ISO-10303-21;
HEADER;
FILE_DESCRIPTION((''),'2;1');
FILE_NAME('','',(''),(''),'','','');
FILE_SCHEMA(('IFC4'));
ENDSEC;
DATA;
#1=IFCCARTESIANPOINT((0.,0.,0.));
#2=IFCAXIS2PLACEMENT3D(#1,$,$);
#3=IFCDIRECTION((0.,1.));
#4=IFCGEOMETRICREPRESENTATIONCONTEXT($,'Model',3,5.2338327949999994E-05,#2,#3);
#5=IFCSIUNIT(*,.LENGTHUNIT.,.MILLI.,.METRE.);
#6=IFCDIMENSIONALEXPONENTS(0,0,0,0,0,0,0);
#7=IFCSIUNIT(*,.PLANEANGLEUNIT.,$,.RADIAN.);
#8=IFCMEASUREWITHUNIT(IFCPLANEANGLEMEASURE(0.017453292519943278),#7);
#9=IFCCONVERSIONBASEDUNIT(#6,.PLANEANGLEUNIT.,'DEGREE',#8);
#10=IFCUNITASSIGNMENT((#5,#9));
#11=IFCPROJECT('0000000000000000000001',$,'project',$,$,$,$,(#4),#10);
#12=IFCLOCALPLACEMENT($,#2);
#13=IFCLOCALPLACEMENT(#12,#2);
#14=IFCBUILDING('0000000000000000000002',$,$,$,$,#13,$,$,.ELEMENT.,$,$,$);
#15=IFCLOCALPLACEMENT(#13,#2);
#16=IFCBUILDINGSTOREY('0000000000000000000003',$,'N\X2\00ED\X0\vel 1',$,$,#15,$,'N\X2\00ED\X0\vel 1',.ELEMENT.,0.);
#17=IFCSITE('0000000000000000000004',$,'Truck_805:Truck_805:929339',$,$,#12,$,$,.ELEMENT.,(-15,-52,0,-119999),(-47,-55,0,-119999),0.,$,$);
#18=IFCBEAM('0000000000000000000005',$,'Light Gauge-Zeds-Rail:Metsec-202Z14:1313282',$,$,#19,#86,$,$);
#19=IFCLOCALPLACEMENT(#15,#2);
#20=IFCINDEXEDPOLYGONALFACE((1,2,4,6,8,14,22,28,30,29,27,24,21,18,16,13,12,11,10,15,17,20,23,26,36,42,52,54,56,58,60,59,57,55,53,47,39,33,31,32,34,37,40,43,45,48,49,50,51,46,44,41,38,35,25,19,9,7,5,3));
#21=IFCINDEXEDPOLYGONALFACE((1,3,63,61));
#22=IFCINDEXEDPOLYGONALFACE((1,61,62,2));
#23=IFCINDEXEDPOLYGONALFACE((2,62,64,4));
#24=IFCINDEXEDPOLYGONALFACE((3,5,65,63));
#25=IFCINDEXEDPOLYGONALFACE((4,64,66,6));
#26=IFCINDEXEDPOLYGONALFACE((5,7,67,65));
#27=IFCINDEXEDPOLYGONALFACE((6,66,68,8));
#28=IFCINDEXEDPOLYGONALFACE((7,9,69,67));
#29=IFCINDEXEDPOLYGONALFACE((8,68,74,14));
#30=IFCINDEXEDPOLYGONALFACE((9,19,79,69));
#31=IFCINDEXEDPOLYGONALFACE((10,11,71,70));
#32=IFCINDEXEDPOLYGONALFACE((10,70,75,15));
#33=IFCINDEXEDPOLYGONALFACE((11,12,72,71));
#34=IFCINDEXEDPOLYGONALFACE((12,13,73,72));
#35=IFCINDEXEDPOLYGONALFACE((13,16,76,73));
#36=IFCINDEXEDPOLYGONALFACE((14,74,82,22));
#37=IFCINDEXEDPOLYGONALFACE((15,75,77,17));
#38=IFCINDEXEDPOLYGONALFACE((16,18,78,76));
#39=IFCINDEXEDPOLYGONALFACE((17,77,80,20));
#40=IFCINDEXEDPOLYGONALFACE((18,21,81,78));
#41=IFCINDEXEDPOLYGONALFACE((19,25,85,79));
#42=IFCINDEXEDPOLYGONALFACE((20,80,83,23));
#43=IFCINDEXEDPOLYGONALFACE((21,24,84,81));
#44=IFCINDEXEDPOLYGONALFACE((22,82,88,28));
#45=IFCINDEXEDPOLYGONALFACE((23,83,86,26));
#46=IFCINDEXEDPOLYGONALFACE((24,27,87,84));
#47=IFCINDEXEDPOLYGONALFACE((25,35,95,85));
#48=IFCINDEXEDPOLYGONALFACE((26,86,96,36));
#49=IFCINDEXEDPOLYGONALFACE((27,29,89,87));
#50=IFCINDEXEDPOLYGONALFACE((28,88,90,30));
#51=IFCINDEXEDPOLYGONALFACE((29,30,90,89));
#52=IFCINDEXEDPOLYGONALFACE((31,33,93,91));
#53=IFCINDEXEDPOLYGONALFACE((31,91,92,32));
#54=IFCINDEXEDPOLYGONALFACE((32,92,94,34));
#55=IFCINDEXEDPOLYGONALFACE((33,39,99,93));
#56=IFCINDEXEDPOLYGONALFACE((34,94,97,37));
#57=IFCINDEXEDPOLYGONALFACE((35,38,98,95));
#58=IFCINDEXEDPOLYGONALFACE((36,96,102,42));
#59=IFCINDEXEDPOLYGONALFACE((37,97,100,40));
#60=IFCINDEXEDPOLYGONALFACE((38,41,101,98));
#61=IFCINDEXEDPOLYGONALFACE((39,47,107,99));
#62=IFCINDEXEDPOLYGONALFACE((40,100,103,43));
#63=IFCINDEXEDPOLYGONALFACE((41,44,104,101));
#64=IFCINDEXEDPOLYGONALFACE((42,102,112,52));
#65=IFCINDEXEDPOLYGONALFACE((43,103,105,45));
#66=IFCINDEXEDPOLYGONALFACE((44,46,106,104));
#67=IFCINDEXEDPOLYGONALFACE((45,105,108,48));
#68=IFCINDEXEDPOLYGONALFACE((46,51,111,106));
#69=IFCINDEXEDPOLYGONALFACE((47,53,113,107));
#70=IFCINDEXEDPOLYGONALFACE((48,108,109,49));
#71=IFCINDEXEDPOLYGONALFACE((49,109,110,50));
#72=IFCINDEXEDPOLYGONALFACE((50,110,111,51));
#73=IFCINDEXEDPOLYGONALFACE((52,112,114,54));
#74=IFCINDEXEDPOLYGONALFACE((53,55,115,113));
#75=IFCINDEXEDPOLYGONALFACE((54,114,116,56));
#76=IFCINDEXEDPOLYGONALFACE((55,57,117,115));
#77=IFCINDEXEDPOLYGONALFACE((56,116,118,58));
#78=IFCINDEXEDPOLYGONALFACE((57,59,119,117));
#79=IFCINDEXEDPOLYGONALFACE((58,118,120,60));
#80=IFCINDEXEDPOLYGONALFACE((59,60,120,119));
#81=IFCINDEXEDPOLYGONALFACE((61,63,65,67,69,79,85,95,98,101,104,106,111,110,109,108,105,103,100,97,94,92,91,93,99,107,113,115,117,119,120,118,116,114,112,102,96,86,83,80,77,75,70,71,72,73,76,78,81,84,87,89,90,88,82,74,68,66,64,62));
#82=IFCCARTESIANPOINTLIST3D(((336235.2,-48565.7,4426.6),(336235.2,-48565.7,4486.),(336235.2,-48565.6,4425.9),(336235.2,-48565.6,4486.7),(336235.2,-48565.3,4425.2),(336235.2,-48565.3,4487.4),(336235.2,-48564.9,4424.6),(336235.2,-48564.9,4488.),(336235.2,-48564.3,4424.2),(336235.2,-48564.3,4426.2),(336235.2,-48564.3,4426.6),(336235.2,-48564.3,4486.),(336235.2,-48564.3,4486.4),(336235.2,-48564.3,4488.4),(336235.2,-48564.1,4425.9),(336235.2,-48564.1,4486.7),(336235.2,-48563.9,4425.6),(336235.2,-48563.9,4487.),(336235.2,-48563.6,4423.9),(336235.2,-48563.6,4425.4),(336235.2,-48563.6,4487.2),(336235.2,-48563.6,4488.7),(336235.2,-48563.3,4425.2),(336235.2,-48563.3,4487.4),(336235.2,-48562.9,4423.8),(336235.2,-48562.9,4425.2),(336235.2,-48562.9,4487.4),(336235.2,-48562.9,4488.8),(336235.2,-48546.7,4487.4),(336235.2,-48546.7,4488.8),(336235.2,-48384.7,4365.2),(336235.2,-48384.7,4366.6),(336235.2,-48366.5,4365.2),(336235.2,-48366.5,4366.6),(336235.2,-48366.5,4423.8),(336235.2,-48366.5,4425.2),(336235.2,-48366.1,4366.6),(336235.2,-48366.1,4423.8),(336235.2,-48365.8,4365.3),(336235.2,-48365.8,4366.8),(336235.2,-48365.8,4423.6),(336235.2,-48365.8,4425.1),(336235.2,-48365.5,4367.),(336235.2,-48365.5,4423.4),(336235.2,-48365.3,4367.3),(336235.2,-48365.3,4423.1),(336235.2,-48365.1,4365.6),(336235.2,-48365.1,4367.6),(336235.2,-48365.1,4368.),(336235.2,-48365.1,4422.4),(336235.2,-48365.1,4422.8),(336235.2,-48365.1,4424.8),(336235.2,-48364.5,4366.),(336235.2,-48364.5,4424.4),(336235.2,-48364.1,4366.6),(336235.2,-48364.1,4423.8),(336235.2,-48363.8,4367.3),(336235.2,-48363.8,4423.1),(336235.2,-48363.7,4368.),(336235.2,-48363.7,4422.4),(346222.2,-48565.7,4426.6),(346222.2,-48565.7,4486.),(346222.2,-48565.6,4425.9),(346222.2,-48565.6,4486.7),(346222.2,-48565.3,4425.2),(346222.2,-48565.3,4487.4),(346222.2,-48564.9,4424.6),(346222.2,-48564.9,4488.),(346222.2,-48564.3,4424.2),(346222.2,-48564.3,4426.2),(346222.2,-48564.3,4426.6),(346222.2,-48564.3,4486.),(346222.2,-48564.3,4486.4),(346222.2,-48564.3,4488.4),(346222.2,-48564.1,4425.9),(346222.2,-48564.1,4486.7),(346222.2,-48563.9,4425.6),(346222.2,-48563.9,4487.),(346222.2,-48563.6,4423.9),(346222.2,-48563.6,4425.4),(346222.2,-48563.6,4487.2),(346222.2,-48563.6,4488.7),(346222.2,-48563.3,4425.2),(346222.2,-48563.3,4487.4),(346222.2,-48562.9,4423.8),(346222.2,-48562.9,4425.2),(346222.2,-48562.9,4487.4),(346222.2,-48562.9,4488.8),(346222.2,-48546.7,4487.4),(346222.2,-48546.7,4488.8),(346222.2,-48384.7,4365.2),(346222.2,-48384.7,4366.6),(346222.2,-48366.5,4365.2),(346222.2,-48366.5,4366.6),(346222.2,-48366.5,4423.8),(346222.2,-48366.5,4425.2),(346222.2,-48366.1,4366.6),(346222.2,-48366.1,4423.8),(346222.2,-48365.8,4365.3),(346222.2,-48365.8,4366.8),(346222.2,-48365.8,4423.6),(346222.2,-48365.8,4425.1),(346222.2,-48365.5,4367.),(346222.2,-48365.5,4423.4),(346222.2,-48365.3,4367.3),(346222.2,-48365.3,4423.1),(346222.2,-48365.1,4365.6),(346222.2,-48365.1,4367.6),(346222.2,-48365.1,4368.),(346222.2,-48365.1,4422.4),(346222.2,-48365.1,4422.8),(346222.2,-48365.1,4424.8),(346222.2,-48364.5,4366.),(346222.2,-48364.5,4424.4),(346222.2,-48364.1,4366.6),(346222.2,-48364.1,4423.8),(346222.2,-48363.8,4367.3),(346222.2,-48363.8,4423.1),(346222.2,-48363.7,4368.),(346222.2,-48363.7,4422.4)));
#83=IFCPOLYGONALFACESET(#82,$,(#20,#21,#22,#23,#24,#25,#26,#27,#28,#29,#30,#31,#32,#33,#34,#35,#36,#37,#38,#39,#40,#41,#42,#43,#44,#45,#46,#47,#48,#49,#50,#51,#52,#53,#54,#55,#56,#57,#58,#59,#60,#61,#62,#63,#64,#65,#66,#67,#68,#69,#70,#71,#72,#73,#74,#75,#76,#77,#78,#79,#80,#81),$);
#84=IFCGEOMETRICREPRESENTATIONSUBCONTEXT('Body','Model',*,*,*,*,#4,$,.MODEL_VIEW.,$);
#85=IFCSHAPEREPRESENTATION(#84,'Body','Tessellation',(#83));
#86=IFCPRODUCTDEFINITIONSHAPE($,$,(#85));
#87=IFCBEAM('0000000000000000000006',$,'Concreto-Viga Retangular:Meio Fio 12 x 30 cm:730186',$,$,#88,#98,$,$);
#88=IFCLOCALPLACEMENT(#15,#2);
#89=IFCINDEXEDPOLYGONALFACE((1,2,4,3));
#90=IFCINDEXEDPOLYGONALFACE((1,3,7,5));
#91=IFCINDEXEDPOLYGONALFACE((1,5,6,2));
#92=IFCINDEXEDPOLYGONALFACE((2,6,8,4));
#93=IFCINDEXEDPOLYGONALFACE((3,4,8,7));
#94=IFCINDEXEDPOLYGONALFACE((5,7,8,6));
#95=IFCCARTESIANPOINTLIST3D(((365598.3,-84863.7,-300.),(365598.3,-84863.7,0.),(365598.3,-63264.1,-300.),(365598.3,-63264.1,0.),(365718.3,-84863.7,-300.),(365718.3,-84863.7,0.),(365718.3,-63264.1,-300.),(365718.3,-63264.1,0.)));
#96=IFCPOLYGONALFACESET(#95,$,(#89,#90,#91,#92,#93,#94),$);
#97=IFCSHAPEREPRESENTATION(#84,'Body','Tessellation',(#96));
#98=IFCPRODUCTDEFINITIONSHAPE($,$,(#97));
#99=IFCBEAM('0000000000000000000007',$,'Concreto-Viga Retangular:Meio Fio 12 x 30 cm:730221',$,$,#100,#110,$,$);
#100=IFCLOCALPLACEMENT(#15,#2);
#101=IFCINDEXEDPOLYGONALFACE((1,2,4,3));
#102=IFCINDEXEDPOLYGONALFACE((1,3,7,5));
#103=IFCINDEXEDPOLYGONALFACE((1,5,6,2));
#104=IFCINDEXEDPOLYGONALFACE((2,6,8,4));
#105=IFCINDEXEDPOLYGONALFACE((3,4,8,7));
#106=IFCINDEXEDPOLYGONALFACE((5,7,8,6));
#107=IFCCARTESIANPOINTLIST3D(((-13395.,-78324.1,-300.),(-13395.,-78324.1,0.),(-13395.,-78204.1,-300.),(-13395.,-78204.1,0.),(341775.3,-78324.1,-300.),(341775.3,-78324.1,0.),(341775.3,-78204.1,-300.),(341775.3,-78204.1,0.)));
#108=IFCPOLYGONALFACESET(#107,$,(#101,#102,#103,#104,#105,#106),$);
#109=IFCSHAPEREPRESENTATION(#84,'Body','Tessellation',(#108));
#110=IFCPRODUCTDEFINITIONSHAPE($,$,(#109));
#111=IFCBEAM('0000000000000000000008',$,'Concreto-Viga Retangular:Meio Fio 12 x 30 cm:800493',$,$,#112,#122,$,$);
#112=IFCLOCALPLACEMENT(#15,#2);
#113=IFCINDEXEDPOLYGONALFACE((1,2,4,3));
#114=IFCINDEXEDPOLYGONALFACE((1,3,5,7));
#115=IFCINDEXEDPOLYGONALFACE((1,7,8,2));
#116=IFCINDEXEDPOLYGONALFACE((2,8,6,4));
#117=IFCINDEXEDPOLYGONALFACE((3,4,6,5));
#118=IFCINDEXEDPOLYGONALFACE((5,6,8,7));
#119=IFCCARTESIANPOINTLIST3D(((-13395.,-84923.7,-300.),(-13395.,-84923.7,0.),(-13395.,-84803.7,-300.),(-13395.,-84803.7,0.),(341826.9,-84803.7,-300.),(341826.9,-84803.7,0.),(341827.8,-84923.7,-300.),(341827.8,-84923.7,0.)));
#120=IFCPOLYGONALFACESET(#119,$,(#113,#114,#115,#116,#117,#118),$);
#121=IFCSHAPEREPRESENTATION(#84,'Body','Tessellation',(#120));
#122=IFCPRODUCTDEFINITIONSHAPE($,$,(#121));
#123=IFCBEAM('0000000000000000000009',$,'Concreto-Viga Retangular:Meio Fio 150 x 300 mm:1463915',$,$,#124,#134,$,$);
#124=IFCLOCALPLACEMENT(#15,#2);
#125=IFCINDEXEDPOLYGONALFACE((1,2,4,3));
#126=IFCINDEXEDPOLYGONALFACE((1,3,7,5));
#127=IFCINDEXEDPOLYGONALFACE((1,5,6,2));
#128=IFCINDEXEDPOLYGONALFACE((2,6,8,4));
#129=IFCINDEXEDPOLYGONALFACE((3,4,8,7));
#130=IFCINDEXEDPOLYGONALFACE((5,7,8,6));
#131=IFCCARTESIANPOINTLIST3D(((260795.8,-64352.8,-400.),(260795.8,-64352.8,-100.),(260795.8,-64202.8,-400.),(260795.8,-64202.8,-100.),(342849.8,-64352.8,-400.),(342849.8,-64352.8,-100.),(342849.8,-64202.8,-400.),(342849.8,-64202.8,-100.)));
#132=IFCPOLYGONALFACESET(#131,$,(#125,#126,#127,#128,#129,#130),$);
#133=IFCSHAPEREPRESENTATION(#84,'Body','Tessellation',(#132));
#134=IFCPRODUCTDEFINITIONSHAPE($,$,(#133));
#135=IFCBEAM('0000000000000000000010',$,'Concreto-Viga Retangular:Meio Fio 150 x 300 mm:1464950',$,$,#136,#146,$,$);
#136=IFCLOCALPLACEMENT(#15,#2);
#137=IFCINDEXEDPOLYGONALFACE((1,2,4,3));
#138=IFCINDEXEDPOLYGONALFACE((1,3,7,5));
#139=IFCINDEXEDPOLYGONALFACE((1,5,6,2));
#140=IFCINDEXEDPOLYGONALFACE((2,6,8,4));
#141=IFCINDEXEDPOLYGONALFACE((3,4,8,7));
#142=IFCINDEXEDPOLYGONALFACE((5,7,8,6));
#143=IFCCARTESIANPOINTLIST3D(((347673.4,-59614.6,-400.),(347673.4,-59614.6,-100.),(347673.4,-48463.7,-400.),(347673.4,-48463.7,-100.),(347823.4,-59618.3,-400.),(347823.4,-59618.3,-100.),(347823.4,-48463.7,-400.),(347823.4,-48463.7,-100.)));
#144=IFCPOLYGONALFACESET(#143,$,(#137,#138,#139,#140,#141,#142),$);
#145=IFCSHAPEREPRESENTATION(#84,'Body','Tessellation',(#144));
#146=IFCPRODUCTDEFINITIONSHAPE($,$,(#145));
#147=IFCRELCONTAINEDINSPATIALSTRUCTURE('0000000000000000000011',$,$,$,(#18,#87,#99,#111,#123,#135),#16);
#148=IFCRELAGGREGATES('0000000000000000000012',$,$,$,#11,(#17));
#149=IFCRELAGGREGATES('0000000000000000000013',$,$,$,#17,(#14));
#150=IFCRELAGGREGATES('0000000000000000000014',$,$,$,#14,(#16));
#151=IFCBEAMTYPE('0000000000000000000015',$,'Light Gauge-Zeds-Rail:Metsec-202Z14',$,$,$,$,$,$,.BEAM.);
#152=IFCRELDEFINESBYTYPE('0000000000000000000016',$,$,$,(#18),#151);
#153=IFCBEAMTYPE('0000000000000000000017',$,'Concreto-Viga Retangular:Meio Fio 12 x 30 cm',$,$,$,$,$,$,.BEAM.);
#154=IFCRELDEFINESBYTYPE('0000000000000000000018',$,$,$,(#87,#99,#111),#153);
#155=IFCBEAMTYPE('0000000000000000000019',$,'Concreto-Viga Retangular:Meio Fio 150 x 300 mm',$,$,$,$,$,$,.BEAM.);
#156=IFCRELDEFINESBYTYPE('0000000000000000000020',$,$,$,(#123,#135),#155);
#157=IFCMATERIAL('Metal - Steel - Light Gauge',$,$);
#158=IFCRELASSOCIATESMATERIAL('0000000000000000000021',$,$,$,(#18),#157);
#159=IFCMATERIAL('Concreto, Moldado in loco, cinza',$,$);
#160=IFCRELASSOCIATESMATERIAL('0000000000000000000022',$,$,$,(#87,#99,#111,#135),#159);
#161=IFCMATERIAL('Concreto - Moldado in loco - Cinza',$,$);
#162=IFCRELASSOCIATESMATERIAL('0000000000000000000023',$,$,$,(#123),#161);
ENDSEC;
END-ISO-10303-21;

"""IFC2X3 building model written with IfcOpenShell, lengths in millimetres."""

from ifc_helpers import new_model, entity, si_unit, converted_unit, direction, frame, frame_2d, origin, origin_2d_with_axis, place, context, subcontext, project, spatial, polyline, circle_curve, parameter, trimmed, segment, composite_curve, rectangle, outline, extrude, clip, halfspace, material, type_object, element, save


model = new_model("IFC2X3")

# Units and contexts
model_context = context("Model", 3, precision=5.2338327949999994e-05, world=origin(), true_north=direction((0.0, 1.0)))
body_context = subcontext(model_context, "Body", "Model", "MODEL_VIEW")
ifc_project = project(units=[si_unit("LENGTHUNIT", "METRE", prefix="MILLI"), converted_unit("PLANEANGLEUNIT", "DEGREE", entity("IfcPlaneAngleMeasure", 0.017453292519943278), si_unit("PLANEANGLEUNIT", "RADIAN"), dimensions=[0, 0, 0, 0, 0, 0, 0])], contexts=[model_context])

# Site, building, storey
site_placement = place(None, origin())
site = spatial("IfcSite", under=ifc_project, at=site_placement, Name="Truck_805:Truck_805:929339", CompositionType="ELEMENT", RefLatitude=(-15, -52, 0, -119999), RefLongitude=(-47, -55, 0, -119999), RefElevation=0.0)
building_placement = place(site_placement, origin())
building = spatial("IfcBuilding", under=site, at=building_placement, CompositionType="ELEMENT")
storey_placement = place(building_placement, origin())
storey = spatial("IfcBuildingStorey", under=building, at=storey_placement, Name="Nível 1", LongName="Nível 1", CompositionType="ELEMENT", Elevation=0.0)

# Beams
ifc_material_1 = material(Name="Metal - Steel - Light Gauge")
beam_type_1 = type_object("IfcBeamType", Name="Light Gauge-Zeds-Rail:Metsec-202Z14", PredefinedType="BEAM")
beam_1_placement = place(storey_placement, frame((336222.2, -48465.6, 4488.8)))
element("IfcBeam", 1, at=beam_1_placement, inside=storey, type_object=beam_type_1, material=ifc_material_1, Name="Light Gauge-Zeds-Rail:Metsec-202Z14:1313282", context=body_context, shape_type="SweptSolid", body=[
    extrude(outline(composite_curve([segment(polyline([(-60.0, -100.8), (-0.6, -100.8)]), True, "CONTINUOUS"), segment(trimmed(circle_curve(frame_2d((-0.6, -98.0), x_axis=(0.0, -1.0)), 2.8), [parameter(0.0)], [parameter(90.0)], True, "PARAMETER"), True, "CONTINUOUS"), segment(polyline([(2.2, -98.0), (2.2, 98.4)]), True, "CONTINUOUS"), segment(trimmed(circle_curve(frame_2d((3.6, 98.4), x_axis=(-1.0, 0.0)), 1.4), [parameter(270.0)], [parameter(0.0)], True, "PARAMETER"), False, "CONTINUOUS"), segment(polyline([(3.6, 99.8), (58.0, 99.8)]), True, "CONTINUOUS"), segment(trimmed(circle_curve(frame_2d((58.0, 98.4), x_axis=(0.0, 1.0)), 1.4), [parameter(270.0)], [parameter(0.0)], True, "PARAMETER"), False, "CONTINUOUS"), segment(polyline([(59.4, 98.4), (59.4, 80.2)]), True, "CONTINUOUS"), segment(polyline([(59.4, 80.2), (60.8, 80.2)]), True, "CONTINUOUS"), segment(polyline([(60.8, 80.2), (60.8, 98.4)]), True, "CONTINUOUS"), segment(trimmed(circle_curve(frame_2d((58.0, 98.4), x_axis=(1.0, 0.0)), 2.8), [parameter(0.0)], [parameter(90.0)], True, "PARAMETER"), True, "CONTINUOUS"), segment(polyline([(58.0, 101.2), (3.6, 101.2)]), True, "CONTINUOUS"), segment(trimmed(circle_curve(frame_2d((3.6, 98.4), x_axis=(0.0, 1.0)), 2.8), [parameter(0.0)], [parameter(90.0)], True, "PARAMETER"), True, "CONTINUOUS"), segment(polyline([(0.8, 98.4), (0.8, -98.0)]), True, "CONTINUOUS"), segment(trimmed(circle_curve(frame_2d((-0.6, -98.0), x_axis=(1.0, 0.0)), 1.4), [parameter(270.0)], [parameter(0.0)], True, "PARAMETER"), False, "CONTINUOUS"), segment(polyline([(-0.6, -99.4), (-60.0, -99.4)]), True, "CONTINUOUS"), segment(trimmed(circle_curve(frame_2d((-60.0, -98.0), x_axis=(0.0, -1.0)), 1.4), [parameter(270.0)], [parameter(0.0)], True, "PARAMETER"), False, "CONTINUOUS"), segment(polyline([(-61.4, -98.0), (-61.4, -81.8)]), True, "CONTINUOUS"), segment(polyline([(-61.4, -81.8), (-62.8, -81.8)]), True, "CONTINUOUS"), segment(polyline([(-62.8, -81.8), (-62.8, -98.0)]), True, "CONTINUOUS"), segment(trimmed(circle_curve(frame_2d((-60.0, -98.0), x_axis=(-1.0, 0.0)), 2.8), [parameter(0.0)], [parameter(90.0)], True, "PARAMETER"), True, "CONTINUOUS")], self_intersect=False)), frame((13.0, 0.7, -62.8), z_axis=(1.0, 0.0, 0.0), x_axis=(0.0, 0.0, -1.0)), (0.0, 0.0, 1.0), 9987.0),
])
ifc_material_2 = material(Name="Concreto, Moldado in loco, cinza")
beam_type_2 = type_object("IfcBeamType", Name="Concreto-Viga Retangular:Meio Fio 12 x 30 cm", PredefinedType="BEAM")
beam_2_placement = place(storey_placement, frame((365658.3, -63264.1, 0.0), z_axis=(0.0, 0.0, 1.0), x_axis=(0.0, -1.0, 0.0)))
element("IfcBeam", 2, at=beam_2_placement, inside=storey, type_object=beam_type_2, material=ifc_material_2, Name="Concreto-Viga Retangular:Meio Fio 12 x 30 cm:730186", context=body_context, shape_type="SweptSolid", body=[
    extrude(rectangle(XDim=300.0, YDim=120.0, at=frame_2d((0.0, 0.0), x_axis=(1.0, 0.0))), frame((0.0, 0.0, -150.0), z_axis=(1.0, 0.0, 0.0), x_axis=(0.0, 0.0, -1.0)), (0.0, 0.0, 1.0), 21599.6),
])
beam_3_placement = place(storey_placement, frame((341775.3, -78264.1, 0.0), z_axis=(0.0, 0.0, 1.0), x_axis=(-1.0, 0.0, 0.0)))
element("IfcBeam", 3, at=beam_3_placement, inside=storey, type_object=beam_type_2, material=ifc_material_2, Name="Concreto-Viga Retangular:Meio Fio 12 x 30 cm:730221", context=body_context, shape_type="SweptSolid", body=[
    extrude(rectangle(XDim=300.0, YDim=120.0, at=frame_2d((0.0, 0.0), x_axis=(1.0, 0.0))), frame((0.0, 0.0, -150.0), z_axis=(1.0, 0.0, 0.0), x_axis=(0.0, 0.0, -1.0)), (0.0, 0.0, 1.0), 355170.3),
])
beam_4_placement = place(storey_placement, frame((341827.3, -84863.7, 0.0), z_axis=(0.0, 0.0, 1.0), x_axis=(-1.0, 0.0, 0.0)))
element("IfcBeam", 4, at=beam_4_placement, inside=storey, type_object=beam_type_2, material=ifc_material_2, Name="Concreto-Viga Retangular:Meio Fio 12 x 30 cm:800493", context=body_context, shape_type="Clipping", body=[
    clip(extrude(rectangle(XDim=300.0, YDim=120.0, at=frame_2d((0.0, 0.0), x_axis=(1.0, 0.0))), frame((-0.5, 0.0, -150.0), z_axis=(1.0, 0.0, 0.0), x_axis=(0.0, 0.0, -1.0)), (0.0, 0.0, 1.0), 355222.8), halfspace(frame((0.5, -60.0, 0.0), z_axis=(-0.999969, -0.007881, 0.0), x_axis=(-0.007881, 0.999969, 0.0)), False)),
])
ifc_material_3 = material(Name="Concreto - Moldado in loco - Cinza")
beam_type_3 = type_object("IfcBeamType", Name="Concreto-Viga Retangular:Meio Fio 150 x 300 mm", PredefinedType="BEAM")
beam_5_placement = place(storey_placement, frame((342849.8, -64277.8, -100.0), z_axis=(0.0, 0.0, 1.0), x_axis=(-1.0, 0.0, 0.0)))
element("IfcBeam", 5, at=beam_5_placement, inside=storey, type_object=beam_type_3, material=ifc_material_3, Name="Concreto-Viga Retangular:Meio Fio 150 x 300 mm:1463915", context=body_context, shape_type="SweptSolid", body=[
    extrude(rectangle(XDim=300.0, YDim=150.0, at=origin_2d_with_axis()), frame((0.0, 0.0, -150.0), z_axis=(1.0, 0.0, 0.0), x_axis=(0.0, 0.0, -1.0)), (0.0, 0.0, 1.0), 82054.1),
])
beam_6_placement = place(storey_placement, frame((347748.4, -59383.7, -100.0), z_axis=(0.0, 0.0, 1.0), x_axis=(0.0, 1.0, 0.0)))
element("IfcBeam", 6, at=beam_6_placement, inside=storey, type_object=beam_type_3, material=ifc_material_2, Name="Concreto-Viga Retangular:Meio Fio 150 x 300 mm:1464950", context=body_context, shape_type="Clipping", body=[
    clip(extrude(rectangle(XDim=300.0, YDim=150.0, at=frame_2d((0.0, 0.0), x_axis=(1.0, 0.0))), frame((-234.6, 0.0, -150.0), z_axis=(1.0, 0.0, 0.0), x_axis=(0.0, 0.0, -1.0)), (0.0, 0.0, 1.0), 11154.6), halfspace(frame((-230.9, 75.0, 0.0), z_axis=(-0.999692, 0.024809, 0.0), x_axis=(-0.024809, -0.999692, 0.0)), False)),
])

save(model, "model.ifc")
